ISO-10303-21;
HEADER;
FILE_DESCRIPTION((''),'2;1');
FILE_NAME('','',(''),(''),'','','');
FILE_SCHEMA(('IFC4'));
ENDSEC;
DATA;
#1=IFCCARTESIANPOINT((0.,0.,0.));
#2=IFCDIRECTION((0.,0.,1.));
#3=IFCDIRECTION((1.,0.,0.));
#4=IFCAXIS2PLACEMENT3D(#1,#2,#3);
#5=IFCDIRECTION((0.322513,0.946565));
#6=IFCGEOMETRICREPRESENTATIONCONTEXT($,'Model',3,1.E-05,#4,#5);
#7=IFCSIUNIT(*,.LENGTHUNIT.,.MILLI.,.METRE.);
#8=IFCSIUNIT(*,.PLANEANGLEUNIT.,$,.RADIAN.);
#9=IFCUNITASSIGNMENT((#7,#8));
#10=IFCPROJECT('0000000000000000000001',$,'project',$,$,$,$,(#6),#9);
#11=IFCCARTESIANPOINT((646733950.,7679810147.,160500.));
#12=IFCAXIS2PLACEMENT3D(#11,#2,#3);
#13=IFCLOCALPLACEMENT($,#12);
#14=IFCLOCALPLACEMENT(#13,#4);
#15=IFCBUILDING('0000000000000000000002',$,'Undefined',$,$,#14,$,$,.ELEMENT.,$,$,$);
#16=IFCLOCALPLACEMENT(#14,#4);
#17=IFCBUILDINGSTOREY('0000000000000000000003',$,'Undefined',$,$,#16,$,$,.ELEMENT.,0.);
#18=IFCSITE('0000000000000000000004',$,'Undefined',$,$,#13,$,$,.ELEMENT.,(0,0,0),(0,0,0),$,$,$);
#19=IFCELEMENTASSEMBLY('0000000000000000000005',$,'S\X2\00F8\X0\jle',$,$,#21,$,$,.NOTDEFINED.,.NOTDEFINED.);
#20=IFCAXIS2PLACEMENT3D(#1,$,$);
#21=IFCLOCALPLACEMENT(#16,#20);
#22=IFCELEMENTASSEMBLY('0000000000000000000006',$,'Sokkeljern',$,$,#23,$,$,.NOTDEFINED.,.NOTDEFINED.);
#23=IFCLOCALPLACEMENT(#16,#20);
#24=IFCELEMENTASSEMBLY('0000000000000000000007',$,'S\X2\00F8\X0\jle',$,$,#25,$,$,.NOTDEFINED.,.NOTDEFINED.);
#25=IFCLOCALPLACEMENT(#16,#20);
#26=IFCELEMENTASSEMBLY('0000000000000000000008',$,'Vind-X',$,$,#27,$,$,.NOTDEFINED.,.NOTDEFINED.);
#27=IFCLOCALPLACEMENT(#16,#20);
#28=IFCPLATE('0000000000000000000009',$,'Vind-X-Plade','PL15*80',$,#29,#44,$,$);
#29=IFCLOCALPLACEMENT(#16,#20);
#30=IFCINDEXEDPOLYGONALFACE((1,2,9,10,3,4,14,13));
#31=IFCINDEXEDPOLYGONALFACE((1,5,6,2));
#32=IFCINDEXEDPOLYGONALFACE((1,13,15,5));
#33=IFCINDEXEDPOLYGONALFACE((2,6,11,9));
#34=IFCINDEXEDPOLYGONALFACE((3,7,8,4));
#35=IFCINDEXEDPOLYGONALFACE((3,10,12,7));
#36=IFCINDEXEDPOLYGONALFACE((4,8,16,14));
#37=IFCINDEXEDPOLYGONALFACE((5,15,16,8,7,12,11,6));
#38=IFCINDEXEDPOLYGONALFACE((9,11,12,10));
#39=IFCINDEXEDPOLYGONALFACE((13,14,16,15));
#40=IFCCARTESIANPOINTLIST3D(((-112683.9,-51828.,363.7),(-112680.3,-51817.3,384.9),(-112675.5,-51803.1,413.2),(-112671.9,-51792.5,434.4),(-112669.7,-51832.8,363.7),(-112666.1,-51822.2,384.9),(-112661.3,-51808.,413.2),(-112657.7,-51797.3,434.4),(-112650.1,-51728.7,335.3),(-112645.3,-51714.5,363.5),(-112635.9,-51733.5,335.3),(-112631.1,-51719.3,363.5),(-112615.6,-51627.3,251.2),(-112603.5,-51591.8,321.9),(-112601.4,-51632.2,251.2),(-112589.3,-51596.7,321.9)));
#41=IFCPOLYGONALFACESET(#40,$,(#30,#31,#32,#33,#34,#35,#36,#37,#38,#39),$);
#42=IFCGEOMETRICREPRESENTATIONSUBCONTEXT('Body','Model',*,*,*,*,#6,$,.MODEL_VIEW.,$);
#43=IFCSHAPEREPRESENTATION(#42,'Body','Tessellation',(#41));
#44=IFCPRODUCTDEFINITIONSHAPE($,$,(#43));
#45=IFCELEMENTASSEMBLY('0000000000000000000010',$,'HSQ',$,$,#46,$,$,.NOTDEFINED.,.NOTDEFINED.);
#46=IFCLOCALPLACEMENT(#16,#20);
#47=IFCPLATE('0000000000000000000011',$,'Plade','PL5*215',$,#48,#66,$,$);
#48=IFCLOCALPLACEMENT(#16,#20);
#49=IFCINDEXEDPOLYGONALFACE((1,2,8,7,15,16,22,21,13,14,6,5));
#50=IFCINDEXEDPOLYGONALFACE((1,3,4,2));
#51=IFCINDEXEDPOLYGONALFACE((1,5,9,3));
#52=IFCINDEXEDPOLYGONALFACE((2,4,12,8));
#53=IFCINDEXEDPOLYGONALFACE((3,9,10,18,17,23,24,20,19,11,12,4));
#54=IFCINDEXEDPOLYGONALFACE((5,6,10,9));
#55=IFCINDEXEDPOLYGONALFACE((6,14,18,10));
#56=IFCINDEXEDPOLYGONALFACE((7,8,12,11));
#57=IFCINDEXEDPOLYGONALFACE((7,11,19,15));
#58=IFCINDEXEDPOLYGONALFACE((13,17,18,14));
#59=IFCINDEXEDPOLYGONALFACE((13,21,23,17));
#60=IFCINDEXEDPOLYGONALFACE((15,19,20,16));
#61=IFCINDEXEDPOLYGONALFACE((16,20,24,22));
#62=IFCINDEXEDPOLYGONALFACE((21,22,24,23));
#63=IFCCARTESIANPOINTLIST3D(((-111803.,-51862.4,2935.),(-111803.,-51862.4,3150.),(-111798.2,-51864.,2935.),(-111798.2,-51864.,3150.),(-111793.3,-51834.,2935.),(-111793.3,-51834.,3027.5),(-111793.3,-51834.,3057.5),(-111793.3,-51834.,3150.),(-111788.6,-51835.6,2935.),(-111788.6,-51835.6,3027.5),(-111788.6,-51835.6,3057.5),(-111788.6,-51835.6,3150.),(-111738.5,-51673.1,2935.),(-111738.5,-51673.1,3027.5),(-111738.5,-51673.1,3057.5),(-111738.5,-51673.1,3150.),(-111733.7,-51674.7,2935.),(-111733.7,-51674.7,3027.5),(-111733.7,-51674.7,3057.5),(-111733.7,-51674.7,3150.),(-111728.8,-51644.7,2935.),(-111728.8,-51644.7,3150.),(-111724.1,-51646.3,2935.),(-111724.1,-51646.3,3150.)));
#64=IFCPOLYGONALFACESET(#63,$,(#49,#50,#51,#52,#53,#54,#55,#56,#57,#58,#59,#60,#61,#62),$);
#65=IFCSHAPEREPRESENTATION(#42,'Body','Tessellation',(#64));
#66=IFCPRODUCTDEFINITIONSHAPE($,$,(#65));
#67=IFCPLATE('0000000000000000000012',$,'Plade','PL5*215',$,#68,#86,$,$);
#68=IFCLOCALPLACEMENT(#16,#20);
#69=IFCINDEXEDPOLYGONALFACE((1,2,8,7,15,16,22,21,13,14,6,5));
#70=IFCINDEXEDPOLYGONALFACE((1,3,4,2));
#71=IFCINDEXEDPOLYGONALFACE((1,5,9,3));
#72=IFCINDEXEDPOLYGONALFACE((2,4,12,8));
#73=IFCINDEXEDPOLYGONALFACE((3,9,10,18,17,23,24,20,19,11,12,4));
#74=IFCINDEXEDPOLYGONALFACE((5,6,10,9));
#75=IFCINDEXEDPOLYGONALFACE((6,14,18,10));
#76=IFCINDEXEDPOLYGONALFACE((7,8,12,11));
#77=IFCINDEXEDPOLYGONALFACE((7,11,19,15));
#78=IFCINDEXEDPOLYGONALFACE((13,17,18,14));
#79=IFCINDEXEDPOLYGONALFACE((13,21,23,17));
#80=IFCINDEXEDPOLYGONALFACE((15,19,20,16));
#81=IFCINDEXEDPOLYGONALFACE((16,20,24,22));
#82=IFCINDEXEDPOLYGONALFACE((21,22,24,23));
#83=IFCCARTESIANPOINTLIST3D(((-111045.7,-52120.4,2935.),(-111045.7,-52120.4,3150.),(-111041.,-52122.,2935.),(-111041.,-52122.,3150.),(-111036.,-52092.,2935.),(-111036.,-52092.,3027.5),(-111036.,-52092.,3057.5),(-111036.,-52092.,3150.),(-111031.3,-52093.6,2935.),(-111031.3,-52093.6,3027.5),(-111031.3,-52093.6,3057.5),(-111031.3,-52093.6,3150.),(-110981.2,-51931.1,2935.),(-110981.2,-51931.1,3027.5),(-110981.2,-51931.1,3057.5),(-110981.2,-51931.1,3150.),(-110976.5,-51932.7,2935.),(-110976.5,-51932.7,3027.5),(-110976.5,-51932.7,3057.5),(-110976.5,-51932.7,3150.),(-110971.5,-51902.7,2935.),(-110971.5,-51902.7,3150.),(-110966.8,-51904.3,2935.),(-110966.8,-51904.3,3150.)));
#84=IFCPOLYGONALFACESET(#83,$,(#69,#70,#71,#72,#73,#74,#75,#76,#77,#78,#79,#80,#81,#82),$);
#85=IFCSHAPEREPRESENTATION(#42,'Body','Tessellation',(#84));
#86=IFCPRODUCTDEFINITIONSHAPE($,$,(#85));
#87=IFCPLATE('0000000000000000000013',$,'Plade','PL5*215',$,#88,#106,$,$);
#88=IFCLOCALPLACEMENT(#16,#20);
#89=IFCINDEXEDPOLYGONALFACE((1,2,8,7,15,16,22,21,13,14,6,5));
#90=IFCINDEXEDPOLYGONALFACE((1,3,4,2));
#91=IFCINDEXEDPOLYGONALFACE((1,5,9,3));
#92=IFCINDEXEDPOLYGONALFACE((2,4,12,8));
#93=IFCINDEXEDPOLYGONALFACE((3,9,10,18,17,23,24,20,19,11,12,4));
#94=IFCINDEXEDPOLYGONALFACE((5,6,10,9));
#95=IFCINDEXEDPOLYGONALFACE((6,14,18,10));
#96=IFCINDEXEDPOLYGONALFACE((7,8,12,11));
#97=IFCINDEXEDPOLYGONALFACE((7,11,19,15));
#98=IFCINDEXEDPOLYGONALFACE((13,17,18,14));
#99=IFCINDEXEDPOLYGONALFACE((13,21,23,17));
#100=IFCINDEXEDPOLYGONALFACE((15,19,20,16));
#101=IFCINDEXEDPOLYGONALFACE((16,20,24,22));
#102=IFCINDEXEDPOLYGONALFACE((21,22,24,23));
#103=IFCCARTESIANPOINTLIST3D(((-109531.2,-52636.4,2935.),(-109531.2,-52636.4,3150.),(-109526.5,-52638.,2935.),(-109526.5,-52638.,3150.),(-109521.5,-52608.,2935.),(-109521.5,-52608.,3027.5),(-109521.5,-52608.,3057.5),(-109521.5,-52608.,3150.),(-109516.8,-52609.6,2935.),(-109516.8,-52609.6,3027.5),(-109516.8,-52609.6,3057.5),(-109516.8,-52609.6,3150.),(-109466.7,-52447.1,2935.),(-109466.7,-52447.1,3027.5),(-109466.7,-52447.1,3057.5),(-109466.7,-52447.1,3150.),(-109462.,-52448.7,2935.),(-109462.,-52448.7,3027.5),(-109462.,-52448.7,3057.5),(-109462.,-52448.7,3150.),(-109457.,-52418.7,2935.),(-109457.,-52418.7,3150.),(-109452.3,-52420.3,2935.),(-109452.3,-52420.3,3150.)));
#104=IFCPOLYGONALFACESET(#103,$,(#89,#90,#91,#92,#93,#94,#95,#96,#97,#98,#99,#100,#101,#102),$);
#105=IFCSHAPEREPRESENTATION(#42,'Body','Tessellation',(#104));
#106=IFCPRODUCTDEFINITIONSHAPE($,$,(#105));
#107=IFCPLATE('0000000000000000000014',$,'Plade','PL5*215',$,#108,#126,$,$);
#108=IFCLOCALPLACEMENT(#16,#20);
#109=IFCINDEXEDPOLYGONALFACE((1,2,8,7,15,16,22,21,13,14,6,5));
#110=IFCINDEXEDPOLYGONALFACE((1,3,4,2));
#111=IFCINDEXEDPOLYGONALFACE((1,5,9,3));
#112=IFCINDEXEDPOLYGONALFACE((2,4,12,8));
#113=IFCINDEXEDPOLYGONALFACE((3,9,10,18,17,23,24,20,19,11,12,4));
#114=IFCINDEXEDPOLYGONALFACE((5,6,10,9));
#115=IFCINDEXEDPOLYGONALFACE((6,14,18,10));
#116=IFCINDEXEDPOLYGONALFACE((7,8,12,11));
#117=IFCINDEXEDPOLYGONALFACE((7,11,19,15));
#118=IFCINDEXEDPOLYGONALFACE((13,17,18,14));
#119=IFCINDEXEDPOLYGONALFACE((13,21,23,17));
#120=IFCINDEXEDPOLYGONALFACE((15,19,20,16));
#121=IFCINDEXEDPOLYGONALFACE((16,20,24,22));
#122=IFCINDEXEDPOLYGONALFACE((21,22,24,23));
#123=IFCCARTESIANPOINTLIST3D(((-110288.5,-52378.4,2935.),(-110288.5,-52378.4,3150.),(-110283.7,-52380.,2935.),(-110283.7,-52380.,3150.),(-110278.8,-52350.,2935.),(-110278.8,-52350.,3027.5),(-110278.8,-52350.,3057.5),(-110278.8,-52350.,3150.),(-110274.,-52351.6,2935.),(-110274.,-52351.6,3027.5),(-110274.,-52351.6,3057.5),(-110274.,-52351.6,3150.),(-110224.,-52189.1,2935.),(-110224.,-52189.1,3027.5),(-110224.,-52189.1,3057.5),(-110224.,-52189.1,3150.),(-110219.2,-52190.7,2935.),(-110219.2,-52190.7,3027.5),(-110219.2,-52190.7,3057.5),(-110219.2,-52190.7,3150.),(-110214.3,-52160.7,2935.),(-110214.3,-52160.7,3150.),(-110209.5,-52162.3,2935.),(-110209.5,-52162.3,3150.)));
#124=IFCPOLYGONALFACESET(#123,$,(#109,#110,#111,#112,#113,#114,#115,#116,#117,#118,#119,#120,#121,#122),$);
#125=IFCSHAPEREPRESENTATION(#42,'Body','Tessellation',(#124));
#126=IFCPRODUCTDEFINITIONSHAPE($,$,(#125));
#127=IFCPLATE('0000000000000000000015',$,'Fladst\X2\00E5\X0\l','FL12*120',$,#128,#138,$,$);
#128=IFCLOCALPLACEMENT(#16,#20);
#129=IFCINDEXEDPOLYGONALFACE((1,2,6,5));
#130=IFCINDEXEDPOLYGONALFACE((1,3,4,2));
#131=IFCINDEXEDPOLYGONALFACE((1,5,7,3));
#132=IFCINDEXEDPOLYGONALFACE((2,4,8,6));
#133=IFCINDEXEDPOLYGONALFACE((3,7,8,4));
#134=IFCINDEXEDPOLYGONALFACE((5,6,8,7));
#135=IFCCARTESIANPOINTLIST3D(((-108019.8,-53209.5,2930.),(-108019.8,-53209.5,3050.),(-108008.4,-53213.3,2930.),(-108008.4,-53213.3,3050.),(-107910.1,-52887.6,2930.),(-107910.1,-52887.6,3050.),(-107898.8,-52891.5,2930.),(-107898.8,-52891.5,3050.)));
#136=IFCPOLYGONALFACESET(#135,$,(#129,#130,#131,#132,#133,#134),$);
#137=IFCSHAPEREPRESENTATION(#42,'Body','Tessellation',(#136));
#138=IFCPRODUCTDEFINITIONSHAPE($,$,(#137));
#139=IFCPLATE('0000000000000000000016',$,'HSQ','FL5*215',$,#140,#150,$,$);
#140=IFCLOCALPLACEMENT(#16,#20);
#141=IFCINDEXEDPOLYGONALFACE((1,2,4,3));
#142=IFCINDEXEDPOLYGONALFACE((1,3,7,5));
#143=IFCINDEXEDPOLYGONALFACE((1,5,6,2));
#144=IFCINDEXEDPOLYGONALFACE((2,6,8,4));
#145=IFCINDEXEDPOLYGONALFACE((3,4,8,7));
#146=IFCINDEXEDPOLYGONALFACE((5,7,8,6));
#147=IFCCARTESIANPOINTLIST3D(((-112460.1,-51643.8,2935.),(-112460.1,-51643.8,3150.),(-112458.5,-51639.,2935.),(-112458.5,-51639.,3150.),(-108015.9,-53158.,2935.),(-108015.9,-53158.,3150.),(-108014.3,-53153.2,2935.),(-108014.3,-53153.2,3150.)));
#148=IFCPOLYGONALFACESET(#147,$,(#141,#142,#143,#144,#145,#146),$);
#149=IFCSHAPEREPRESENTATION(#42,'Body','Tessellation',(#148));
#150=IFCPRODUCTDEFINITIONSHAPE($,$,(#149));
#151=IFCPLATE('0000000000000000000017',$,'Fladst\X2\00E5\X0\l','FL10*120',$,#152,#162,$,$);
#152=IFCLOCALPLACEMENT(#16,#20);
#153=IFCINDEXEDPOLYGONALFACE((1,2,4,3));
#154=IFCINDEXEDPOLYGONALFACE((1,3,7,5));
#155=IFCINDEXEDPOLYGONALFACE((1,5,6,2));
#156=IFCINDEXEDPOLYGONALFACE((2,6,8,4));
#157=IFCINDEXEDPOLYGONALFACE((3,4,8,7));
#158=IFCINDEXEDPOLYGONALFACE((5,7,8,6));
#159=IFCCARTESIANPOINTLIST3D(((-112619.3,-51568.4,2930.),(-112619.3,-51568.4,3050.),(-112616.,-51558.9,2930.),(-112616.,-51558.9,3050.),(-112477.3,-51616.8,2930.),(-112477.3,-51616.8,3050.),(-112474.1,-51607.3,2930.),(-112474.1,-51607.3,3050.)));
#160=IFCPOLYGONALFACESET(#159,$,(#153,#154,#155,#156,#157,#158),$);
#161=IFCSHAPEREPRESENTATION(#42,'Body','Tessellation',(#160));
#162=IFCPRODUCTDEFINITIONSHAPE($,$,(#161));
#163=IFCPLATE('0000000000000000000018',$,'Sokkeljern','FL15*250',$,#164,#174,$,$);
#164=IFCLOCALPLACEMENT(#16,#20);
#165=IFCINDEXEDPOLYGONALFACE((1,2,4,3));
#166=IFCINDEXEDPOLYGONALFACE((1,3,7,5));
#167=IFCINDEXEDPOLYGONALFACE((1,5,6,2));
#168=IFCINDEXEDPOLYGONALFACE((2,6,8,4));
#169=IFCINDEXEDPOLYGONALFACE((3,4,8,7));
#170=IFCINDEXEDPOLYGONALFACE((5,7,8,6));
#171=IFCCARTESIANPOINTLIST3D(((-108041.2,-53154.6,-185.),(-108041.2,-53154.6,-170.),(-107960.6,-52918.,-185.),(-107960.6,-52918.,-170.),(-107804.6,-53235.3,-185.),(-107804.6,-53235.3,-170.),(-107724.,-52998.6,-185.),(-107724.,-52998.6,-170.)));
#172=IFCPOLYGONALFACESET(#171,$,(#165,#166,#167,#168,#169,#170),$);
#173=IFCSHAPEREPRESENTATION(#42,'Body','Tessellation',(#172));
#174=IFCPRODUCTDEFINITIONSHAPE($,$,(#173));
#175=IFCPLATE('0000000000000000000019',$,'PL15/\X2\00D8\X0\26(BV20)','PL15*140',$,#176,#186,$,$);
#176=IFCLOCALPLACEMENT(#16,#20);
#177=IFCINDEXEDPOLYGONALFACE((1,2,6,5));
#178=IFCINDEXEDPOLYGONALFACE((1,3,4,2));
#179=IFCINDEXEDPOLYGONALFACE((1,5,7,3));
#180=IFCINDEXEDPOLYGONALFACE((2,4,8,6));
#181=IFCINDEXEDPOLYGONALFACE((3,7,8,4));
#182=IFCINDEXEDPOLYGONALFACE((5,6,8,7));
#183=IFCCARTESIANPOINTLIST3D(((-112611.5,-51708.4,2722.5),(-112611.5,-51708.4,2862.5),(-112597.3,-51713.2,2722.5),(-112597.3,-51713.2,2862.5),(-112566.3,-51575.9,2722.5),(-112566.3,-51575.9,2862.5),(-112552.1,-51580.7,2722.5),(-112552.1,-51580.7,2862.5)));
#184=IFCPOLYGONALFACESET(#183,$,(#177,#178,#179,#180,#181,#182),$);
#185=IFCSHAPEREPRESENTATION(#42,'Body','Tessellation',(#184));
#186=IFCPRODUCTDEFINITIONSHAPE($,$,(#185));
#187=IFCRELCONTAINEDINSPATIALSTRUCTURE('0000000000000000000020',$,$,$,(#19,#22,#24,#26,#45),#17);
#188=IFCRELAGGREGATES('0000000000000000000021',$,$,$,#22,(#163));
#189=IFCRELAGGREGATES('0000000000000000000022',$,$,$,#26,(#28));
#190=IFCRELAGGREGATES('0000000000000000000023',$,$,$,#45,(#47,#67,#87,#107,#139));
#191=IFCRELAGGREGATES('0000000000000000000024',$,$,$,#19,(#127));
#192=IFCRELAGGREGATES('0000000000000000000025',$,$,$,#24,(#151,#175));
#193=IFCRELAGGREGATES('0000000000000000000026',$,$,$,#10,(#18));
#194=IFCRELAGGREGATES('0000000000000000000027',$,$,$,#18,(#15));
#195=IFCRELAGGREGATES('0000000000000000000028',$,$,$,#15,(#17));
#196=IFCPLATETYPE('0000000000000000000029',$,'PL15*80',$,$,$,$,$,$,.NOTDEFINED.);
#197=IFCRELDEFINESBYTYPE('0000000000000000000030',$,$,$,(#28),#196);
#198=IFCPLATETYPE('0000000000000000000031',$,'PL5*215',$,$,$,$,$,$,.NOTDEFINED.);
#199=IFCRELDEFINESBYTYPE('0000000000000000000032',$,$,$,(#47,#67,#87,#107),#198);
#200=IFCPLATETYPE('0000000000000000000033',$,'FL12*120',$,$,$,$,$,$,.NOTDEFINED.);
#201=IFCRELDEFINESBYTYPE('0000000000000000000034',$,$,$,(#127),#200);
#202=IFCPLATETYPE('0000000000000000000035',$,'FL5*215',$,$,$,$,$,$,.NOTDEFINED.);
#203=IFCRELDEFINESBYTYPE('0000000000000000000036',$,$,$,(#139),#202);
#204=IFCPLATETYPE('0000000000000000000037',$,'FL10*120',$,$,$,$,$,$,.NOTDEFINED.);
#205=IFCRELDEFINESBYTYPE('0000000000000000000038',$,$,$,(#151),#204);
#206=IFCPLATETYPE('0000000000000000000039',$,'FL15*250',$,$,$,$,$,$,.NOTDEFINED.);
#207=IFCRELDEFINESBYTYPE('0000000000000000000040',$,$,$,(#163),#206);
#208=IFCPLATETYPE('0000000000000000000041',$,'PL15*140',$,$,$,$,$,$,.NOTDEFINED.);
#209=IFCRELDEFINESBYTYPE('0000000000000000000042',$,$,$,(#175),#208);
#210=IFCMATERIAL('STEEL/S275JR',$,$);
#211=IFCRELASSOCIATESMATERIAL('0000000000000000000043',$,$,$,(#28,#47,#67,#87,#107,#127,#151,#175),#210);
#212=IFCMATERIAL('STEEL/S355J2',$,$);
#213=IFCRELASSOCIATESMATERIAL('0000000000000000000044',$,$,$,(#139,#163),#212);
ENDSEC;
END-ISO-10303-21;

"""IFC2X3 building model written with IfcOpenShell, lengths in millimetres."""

from ifc_helpers import new_model, si_unit, direction, frame, origin_with_axes, place, context, subcontext, project, spatial, polyline, outline, extrude, boolean, material, type_object, element, aggregate, save


model = new_model("IFC2X3")

# Units and contexts
model_context = context("Model", 3, precision=1e-05, world=origin_with_axes(), true_north=direction((0.322513, 0.946565)))
body_context = subcontext(model_context, "Body", "Model", "MODEL_VIEW")
ifc_project = project(units=[si_unit("LENGTHUNIT", "METRE", prefix="MILLI"), si_unit("PLANEANGLEUNIT", "RADIAN")], contexts=[model_context])

# Site, building, storey
site_placement = place(None, frame((646733950.0, 7679810147.0, 160500.0), z_axis=(0.0, 0.0, 1.0), x_axis=(1.0, 0.0, 0.0)))
site = spatial("IfcSite", under=ifc_project, at=site_placement, Name="Undefined", CompositionType="ELEMENT", RefLatitude=(0, 0, 0), RefLongitude=(0, 0, 0))
building_placement = place(site_placement, origin_with_axes())
building = spatial("IfcBuilding", under=site, at=building_placement, Name="Undefined", CompositionType="ELEMENT")
storey_placement = place(building_placement, origin_with_axes())
storey = spatial("IfcBuildingStorey", under=building, at=storey_placement, Name="Undefined", CompositionType="ELEMENT", Elevation=0.0)

# Shared definitions
ifc_material_1 = material(Name="STEEL/S355J2")

# Element assembly
assembly_1_placement = place(storey_placement, origin_with_axes())
assembly_1 = element("IfcElementAssembly", 1, at=assembly_1_placement, inside=storey, Name="Søjle", AssemblyPlace="NOTDEFINED", PredefinedType="NOTDEFINED")
ifc_material_2 = material(Name="STEEL/S275JR")

# Element assembly
assembly_2_placement = place(storey_placement, origin_with_axes())
assembly_2 = element("IfcElementAssembly", 2, at=assembly_2_placement, inside=storey, Name="Sokkeljern", AssemblyPlace="NOTDEFINED", PredefinedType="NOTDEFINED")

# Element assembly
assembly_3_placement = place(storey_placement, origin_with_axes())
assembly_3 = element("IfcElementAssembly", 3, at=assembly_3_placement, inside=storey, Name="Søjle", AssemblyPlace="NOTDEFINED", PredefinedType="NOTDEFINED")

# Shared definitions
plate_type_1 = type_object("IfcPlateType", Name="PL15*80", PredefinedType="NOTDEFINED")

# Element assembly, plate
assembly_4_placement = place(storey_placement, origin_with_axes())
assembly_4 = element("IfcElementAssembly", 4, at=assembly_4_placement, inside=storey, Name="Vind-X", AssemblyPlace="NOTDEFINED", PredefinedType="NOTDEFINED")
plate_1_placement = place(assembly_4_placement, frame((-112608.5, -51629.7, 251.2), z_axis=(0.946565, -0.322513, 0.0), x_axis=(0.151189, 0.443735, 0.883313)))
plate_1 = element("IfcPlate", 5, at=plate_1_placement, type_object=plate_type_1, material=ifc_material_2, Name="Vind-X-Plade", Description="PL15*80", context=body_context, shape_type="CSG", body=[
    boolean("DIFFERENCE", extrude(outline(polyline([(0.0, 0.0), (80.0, 0.0), (80.0, 240.0), (0.0, 240.0), (0.0, 0.0)])), frame((0.0, 0.0, -7.5), z_axis=(0.0, 0.0, 1.0), x_axis=(1.0, 0.0, 0.0)), (0.0, 0.0, 1.0), 15.0), extrude(outline(polyline([(0.0, 0.0), (106.0, 0.0), (106.0, 32.0), (0.0, 32.0), (0.0, 0.0)])), frame((56.0, 240.0, 8.5), z_axis=(0.0, 0.0, -1.0), x_axis=(0.0, -1.0, 0.0)), (0.0, 0.0, 1.0), 17.0)),
])

# Element assembly, plates
assembly_5_placement = place(storey_placement, origin_with_axes())
assembly_5 = element("IfcElementAssembly", 6, at=assembly_5_placement, inside=storey, Name="HSQ", AssemblyPlace="NOTDEFINED", PredefinedType="NOTDEFINED")
plate_type_2 = type_object("IfcPlateType", Name="PL5*215", PredefinedType="NOTDEFINED")
plate_2_placement = place(assembly_5_placement, frame((-111800.6, -51863.2, 3150.0), z_axis=(0.946565, -0.322513, 0.0), x_axis=(0.0, 0.0, -1.0)))
plate_2 = element("IfcPlate", 7, at=plate_2_placement, type_object=plate_type_2, material=ifc_material_2, Name="Plade", Description="PL5*215", context=body_context, shape_type="SweptSolid", body=[
    extrude(outline(polyline([(0.0, 0.0), (215.0, 0.0), (215.0, 30.0), (122.5, 30.0), (122.5, 200.0), (215.0, 200.0), (215.0, 230.0), (0.0, 230.0), (0.0, 200.0), (92.5, 200.0), (92.5, 30.0), (0.0, 30.0), (0.0, 0.0)])), frame((0.0, 0.0, -2.5), z_axis=(0.0, 0.0, 1.0), x_axis=(1.0, 0.0, 0.0)), (0.0, 0.0, 1.0), 5.0),
])
plate_3_placement = place(assembly_5_placement, frame((-111043.3, -52121.2, 3150.0), z_axis=(0.946565, -0.322513, 0.0), x_axis=(0.0, 0.0, -1.0)))
plate_3 = element("IfcPlate", 8, at=plate_3_placement, type_object=plate_type_2, material=ifc_material_2, Name="Plade", Description="PL5*215", context=body_context, shape_type="SweptSolid", body=[
    extrude(outline(polyline([(0.0, 0.0), (215.0, 0.0), (215.0, 30.0), (122.5, 30.0), (122.5, 200.0), (215.0, 200.0), (215.0, 230.0), (0.0, 230.0), (0.0, 200.0), (92.5, 200.0), (92.5, 30.0), (0.0, 30.0), (0.0, 0.0)])), frame((0.0, 0.0, -2.5), z_axis=(0.0, 0.0, 1.0), x_axis=(1.0, 0.0, 0.0)), (0.0, 0.0, 1.0), 5.0),
])
plate_4_placement = place(assembly_5_placement, frame((-109528.8, -52637.2, 3150.0), z_axis=(0.946565, -0.322513, 0.0), x_axis=(0.0, 0.0, -1.0)))
plate_4 = element("IfcPlate", 9, at=plate_4_placement, type_object=plate_type_2, material=ifc_material_2, Name="Plade", Description="PL5*215", context=body_context, shape_type="SweptSolid", body=[
    extrude(outline(polyline([(0.0, 0.0), (215.0, 0.0), (215.0, 30.0), (122.5, 30.0), (122.5, 200.0), (215.0, 200.0), (215.0, 230.0), (0.0, 230.0), (0.0, 200.0), (92.5, 200.0), (92.5, 30.0), (0.0, 30.0), (0.0, 0.0)])), frame((0.0, 0.0, -2.5), z_axis=(0.0, 0.0, 1.0), x_axis=(1.0, 0.0, 0.0)), (0.0, 0.0, 1.0), 5.0),
])
plate_5_placement = place(assembly_5_placement, frame((-110286.1, -52379.2, 3150.0), z_axis=(0.946565, -0.322513, 0.0), x_axis=(0.0, 0.0, -1.0)))
plate_5 = element("IfcPlate", 10, at=plate_5_placement, type_object=plate_type_2, material=ifc_material_2, Name="Plade", Description="PL5*215", context=body_context, shape_type="SweptSolid", body=[
    extrude(outline(polyline([(0.0, 0.0), (215.0, 0.0), (215.0, 30.0), (122.5, 30.0), (122.5, 200.0), (215.0, 200.0), (215.0, 230.0), (0.0, 230.0), (0.0, 200.0), (92.5, 200.0), (92.5, 30.0), (0.0, 30.0), (0.0, 0.0)])), frame((0.0, 0.0, -2.5), z_axis=(0.0, 0.0, 1.0), x_axis=(1.0, 0.0, 0.0)), (0.0, 0.0, 1.0), 5.0),
])

# Plates
plate_type_3 = type_object("IfcPlateType", Name="FL12*120", PredefinedType="NOTDEFINED")
plate_6_placement = place(assembly_1_placement, frame((-107904.4, -52889.6, 3050.0), z_axis=(0.946565, -0.322513, 0.0), x_axis=(-0.322513, -0.946565, 0.0)))
plate_6 = element("IfcPlate", 11, at=plate_6_placement, type_object=plate_type_3, material=ifc_material_2, Name="Fladstål", Description="FL12*120", context=body_context, shape_type="SweptSolid", body=[
    extrude(outline(polyline([(0.0, 0.0), (340.0, 0.0), (340.0, 120.0), (0.0, 120.0), (0.0, 0.0)])), frame((0.0, 0.0, -6.0), z_axis=(0.0, 0.0, 1.0), x_axis=(1.0, 0.0, 0.0)), (0.0, 0.0, 1.0), 12.0),
])
plate_type_4 = type_object("IfcPlateType", Name="FL5*215", PredefinedType="NOTDEFINED")
plate_7_placement = place(assembly_5_placement, frame((-112459.3, -51641.4, 3042.5), z_axis=(-0.322513, -0.946565, 0.0), x_axis=(0.946565, -0.322513, 0.0)))
plate_7 = element("IfcPlate", 12, at=plate_7_placement, type_object=plate_type_4, material=ifc_material_1, Name="HSQ", Description="FL5*215", context=body_context, shape_type="SweptSolid", body=[
    extrude(outline(polyline([(0.0, -107.5), (0.0, 107.5), (4695.0, 107.5), (4695.0, -107.5), (0.0, -107.5)])), frame((0.0, 0.0, -2.5), z_axis=(0.0, 0.0, 1.0), x_axis=(1.0, 0.0, 0.0)), (0.0, 0.0, 1.0), 5.0),
])
plate_type_5 = type_object("IfcPlateType", Name="FL10*120", PredefinedType="NOTDEFINED")
plate_8_placement = place(assembly_3_placement, frame((-112475.7, -51612.0, 3050.0), z_axis=(-0.322513, -0.946565, 0.0), x_axis=(-0.946565, 0.322513, 0.0)))
plate_8 = element("IfcPlate", 13, at=plate_8_placement, type_object=plate_type_5, material=ifc_material_2, Name="Fladstål", Description="FL10*120", context=body_context, shape_type="SweptSolid", body=[
    extrude(outline(polyline([(0.0, 0.0), (150.0, 0.0), (150.0, 120.0), (0.0, 120.0), (0.0, 0.0)])), frame((0.0, 0.0, -5.0), z_axis=(0.0, 0.0, 1.0), x_axis=(1.0, 0.0, 0.0)), (0.0, 0.0, 1.0), 10.0),
])
plate_type_6 = type_object("IfcPlateType", Name="FL15*250", PredefinedType="NOTDEFINED")
plate_9_placement = place(assembly_2_placement, frame((-107960.6, -52918.0, -177.5), z_axis=(0.0, 0.0, 1.0), x_axis=(-0.322513, -0.946565, 0.0)))
plate_9 = element("IfcPlate", 14, at=plate_9_placement, type_object=plate_type_6, material=ifc_material_1, Name="Sokkeljern", Description="FL15*250", context=body_context, shape_type="SweptSolid", body=[
    extrude(outline(polyline([(0.0, 0.0), (250.0, 0.0), (250.0, 250.0), (0.0, 250.0), (0.0, 0.0)])), frame((0.0, 0.0, -7.5), z_axis=(0.0, 0.0, 1.0), x_axis=(1.0, 0.0, 0.0)), (0.0, 0.0, 1.0), 15.0),
])
aggregate(assembly_2, [plate_9])
plate_type_7 = type_object("IfcPlateType", Name="PL15*140", PredefinedType="NOTDEFINED")
plate_10_placement = place(assembly_3_placement, frame((-112559.2, -51578.3, 2722.5), z_axis=(-0.946565, 0.322513, 0.0), x_axis=(-0.322513, -0.946565, 0.0)))
plate_10 = element("IfcPlate", 15, at=plate_10_placement, type_object=plate_type_7, material=ifc_material_2, Name="PL15/Ø26(BV20)", Description="PL15*140", context=body_context, shape_type="SweptSolid", body=[
    extrude(outline(polyline([(0.0, 0.0), (140.0, 0.0), (140.0, 140.0), (0.0, 140.0), (0.0, 0.0)])), frame((0.0, 0.0, -7.5), z_axis=(0.0, 0.0, 1.0), x_axis=(1.0, 0.0, 0.0)), (0.0, 0.0, 1.0), 15.0),
])

aggregate(assembly_4, [plate_1])
aggregate(assembly_5, [plate_2, plate_3, plate_4, plate_5, plate_7])
aggregate(assembly_1, [plate_6])
aggregate(assembly_3, [plate_8, plate_10])

save(model, "model.ifc")
